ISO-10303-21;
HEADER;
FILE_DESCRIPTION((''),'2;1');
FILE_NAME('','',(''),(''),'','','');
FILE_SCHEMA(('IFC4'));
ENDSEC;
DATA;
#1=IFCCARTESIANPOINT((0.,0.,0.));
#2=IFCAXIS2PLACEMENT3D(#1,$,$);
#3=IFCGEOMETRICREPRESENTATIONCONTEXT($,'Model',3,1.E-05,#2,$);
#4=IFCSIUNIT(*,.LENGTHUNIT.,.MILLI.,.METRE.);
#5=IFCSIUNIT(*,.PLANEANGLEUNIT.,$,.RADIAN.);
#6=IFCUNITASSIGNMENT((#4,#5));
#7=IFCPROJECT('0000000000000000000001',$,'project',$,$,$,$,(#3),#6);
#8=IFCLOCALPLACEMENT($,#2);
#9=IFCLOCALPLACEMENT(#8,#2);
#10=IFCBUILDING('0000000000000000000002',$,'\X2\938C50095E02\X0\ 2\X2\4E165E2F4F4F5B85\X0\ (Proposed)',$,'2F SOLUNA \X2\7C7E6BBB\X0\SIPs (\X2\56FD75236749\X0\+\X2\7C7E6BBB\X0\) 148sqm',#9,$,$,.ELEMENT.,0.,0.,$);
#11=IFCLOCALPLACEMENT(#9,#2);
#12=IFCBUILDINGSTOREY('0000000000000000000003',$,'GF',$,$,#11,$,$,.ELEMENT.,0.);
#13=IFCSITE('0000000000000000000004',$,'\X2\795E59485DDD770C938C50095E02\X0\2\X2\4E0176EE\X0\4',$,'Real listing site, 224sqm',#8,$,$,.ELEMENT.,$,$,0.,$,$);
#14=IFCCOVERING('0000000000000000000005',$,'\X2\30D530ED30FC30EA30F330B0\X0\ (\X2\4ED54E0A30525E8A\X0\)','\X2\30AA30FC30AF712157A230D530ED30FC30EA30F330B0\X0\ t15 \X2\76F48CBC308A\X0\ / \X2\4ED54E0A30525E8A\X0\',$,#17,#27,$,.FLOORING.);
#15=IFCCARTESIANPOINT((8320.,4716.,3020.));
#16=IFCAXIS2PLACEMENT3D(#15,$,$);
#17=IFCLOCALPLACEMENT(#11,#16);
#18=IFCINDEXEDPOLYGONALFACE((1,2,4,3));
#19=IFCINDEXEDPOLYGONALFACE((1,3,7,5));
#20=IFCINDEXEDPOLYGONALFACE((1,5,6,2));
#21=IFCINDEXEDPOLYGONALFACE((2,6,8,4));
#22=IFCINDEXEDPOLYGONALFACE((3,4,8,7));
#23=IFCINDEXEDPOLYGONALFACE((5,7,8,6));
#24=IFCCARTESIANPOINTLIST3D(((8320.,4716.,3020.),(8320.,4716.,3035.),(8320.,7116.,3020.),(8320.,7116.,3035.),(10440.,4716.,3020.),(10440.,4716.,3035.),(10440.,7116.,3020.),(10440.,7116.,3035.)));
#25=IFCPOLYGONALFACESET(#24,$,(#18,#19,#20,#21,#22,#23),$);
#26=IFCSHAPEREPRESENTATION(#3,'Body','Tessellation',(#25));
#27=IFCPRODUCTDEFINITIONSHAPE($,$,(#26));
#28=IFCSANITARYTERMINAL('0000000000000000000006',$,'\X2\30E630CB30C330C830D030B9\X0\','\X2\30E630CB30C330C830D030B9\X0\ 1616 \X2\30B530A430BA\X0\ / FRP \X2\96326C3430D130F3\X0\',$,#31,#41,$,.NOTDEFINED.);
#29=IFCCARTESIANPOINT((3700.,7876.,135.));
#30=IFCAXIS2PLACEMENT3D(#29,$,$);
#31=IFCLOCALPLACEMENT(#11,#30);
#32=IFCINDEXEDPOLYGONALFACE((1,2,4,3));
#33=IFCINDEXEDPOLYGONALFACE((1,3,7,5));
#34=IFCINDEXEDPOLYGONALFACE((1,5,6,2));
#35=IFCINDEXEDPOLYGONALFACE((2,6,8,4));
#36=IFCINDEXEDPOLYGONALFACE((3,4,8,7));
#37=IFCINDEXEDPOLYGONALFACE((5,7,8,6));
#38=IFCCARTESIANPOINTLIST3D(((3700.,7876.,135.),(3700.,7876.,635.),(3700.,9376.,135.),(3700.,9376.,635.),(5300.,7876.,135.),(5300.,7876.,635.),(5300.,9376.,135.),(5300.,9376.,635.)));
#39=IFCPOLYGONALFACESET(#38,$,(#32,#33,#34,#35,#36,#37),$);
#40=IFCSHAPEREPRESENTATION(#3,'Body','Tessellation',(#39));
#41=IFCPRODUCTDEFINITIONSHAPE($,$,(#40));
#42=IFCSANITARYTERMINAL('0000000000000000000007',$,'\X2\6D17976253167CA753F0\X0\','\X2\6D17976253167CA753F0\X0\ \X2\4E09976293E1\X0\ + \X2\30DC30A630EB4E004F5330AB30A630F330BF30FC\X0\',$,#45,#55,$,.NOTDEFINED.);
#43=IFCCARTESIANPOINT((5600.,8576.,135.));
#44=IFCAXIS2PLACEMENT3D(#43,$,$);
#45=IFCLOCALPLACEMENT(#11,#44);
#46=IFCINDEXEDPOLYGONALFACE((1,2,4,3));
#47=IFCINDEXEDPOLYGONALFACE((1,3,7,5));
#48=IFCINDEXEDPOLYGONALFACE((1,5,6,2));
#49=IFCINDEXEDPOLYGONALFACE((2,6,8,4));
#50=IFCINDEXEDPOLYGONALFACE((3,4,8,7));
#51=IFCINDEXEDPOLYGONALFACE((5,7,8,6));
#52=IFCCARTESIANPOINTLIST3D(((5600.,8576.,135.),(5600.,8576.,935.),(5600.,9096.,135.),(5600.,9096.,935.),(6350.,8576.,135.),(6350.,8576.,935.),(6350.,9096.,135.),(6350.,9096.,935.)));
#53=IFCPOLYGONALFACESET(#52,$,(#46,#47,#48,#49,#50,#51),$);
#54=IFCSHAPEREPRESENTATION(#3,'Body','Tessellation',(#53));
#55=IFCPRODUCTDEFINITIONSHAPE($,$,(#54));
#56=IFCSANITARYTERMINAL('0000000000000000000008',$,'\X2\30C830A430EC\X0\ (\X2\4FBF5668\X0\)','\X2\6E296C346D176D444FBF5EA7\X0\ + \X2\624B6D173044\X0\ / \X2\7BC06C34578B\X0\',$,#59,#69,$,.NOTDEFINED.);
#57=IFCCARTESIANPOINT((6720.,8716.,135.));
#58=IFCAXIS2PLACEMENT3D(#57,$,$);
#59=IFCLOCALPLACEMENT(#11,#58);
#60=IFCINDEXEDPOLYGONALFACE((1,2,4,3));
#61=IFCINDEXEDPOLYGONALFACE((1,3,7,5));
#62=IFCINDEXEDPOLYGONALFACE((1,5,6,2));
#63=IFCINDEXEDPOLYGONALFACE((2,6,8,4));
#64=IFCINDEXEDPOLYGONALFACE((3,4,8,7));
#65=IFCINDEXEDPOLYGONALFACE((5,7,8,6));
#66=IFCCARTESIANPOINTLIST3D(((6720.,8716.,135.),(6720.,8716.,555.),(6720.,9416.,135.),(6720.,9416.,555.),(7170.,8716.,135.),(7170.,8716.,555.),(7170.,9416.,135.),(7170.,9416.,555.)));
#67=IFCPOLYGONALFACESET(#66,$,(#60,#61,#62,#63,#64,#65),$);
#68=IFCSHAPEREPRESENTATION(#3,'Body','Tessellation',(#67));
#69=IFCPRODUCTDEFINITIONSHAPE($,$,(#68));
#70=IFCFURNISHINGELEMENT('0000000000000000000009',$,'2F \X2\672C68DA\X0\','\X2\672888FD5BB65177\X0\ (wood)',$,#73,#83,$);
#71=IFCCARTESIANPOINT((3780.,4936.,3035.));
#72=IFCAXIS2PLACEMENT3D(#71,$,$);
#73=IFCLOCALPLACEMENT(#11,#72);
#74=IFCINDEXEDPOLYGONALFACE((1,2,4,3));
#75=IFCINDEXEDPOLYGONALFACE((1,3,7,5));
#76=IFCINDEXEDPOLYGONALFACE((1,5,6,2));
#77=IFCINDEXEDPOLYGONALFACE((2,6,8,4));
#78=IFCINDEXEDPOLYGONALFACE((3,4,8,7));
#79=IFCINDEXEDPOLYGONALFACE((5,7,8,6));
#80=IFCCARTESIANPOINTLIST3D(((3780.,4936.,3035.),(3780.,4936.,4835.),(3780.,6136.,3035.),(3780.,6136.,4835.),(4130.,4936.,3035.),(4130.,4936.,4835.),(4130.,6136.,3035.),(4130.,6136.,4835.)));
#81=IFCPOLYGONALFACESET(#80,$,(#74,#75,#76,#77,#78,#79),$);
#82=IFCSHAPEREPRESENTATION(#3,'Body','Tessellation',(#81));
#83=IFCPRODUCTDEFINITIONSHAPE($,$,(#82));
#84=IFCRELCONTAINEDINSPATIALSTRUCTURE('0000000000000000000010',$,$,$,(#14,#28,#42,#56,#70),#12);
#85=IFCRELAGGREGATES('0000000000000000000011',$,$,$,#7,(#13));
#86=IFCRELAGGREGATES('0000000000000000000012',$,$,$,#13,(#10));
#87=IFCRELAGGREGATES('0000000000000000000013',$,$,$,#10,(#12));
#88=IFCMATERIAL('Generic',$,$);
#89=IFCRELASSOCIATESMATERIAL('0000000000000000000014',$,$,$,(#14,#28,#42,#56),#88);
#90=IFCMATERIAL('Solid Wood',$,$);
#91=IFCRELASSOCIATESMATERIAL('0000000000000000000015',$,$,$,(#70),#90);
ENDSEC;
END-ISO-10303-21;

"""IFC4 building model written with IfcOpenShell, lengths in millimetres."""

from ifc_helpers import new_model, si_unit, frame, frame_2d, origin, place, context, project, spatial, rectangle, extrude, material, element, save


model = new_model("IFC4")

# Units and contexts
model_context = context("Model", 3, precision=1e-05, world=origin())
ifc_project = project(units=[si_unit("LENGTHUNIT", "METRE", prefix="MILLI"), si_unit("PLANEANGLEUNIT", "RADIAN")], contexts=[model_context])

# Site, building, storey
site_placement = place(None, origin())
site = spatial("IfcSite", under=ifc_project, at=site_placement, Name="神奈川県鎌倉市2丁目4", ObjectType="Real listing site, 224sqm", CompositionType="ELEMENT", RefElevation=0.0)
building_placement = place(site_placement, origin())
building = spatial("IfcBuilding", under=site, at=building_placement, Name="鎌倉市 2世帯住宅 (Proposed)", ObjectType="2F SOLUNA 籾殻SIPs (国産杉+籾殻) 148sqm", CompositionType="ELEMENT", ElevationOfRefHeight=0.0, ElevationOfTerrain=0.0)
storey_placement = place(building_placement, origin())
storey = spatial("IfcBuildingStorey", under=building, at=storey_placement, Name="GF", CompositionType="ELEMENT", Elevation=0.0)

# Shared definitions
ifc_material_1 = material(Name="Solid Wood")
ifc_material_2 = material(Name="Generic")

# Covering
covering_1_placement = place(storey_placement, frame((8320.0, 4716.0, 3020.0)))
element("IfcCovering", 1, at=covering_1_placement, inside=storey, material=ifc_material_2, Name="フローリング (仕上げ床)", Description="オーク無垢フローリング t15 直貼り / 仕上げ床", PredefinedType="FLOORING", context=model_context, shape_type="SweptSolid", body=[
    extrude(rectangle(XDim=2120.0, YDim=2400.0, at=frame_2d((1060.0, 1200.0))), frame((8320.0, 4716.0, 3020.0)), (0.0, 0.0, 1.0), 15.0),
])

# Sanitary terminals
sanitary_terminal_1_placement = place(storey_placement, frame((3700.0, 7876.0, 135.0)))
element("IfcSanitaryTerminal", 2, at=sanitary_terminal_1_placement, inside=storey, material=ifc_material_2, Name="ユニットバス", Description="ユニットバス 1616 サイズ / FRP 防水パン", PredefinedType="NOTDEFINED", context=model_context, shape_type="SweptSolid", body=[
    extrude(rectangle(XDim=1600.0, YDim=1500.0, at=frame_2d((800.0, 750.0))), frame((3700.0, 7876.0, 135.0)), (0.0, 0.0, 1.0), 500.0),
])
sanitary_terminal_2_placement = place(storey_placement, frame((5600.0, 8576.0, 135.0)))
element("IfcSanitaryTerminal", 3, at=sanitary_terminal_2_placement, inside=storey, material=ifc_material_2, Name="洗面化粧台", Description="洗面化粧台 三面鏡 + ボウル一体カウンター", PredefinedType="NOTDEFINED", context=model_context, shape_type="SweptSolid", body=[
    extrude(rectangle(XDim=750.0, YDim=520.0, at=frame_2d((375.0, 260.0))), frame((5600.0, 8576.0, 135.0)), (0.0, 0.0, 1.0), 800.0),
])
sanitary_terminal_3_placement = place(storey_placement, frame((6720.0, 8716.0, 135.0)))
element("IfcSanitaryTerminal", 4, at=sanitary_terminal_3_placement, inside=storey, material=ifc_material_2, Name="トイレ (便器)", Description="温水洗浄便座 + 手洗い / 節水型", PredefinedType="NOTDEFINED", context=model_context, shape_type="SweptSolid", body=[
    extrude(rectangle(XDim=450.0, YDim=700.0, at=frame_2d((225.0, 350.0))), frame((6720.0, 8716.0, 135.0)), (0.0, 0.0, 1.0), 420.0),
])

# Furnishing element
furnishing_placement = place(storey_placement, frame((3780.0, 4936.0, 3035.0)))
element("IfcFurnishingElement", 5, at=furnishing_placement, inside=storey, material=ifc_material_1, Name="2F 本棚", Description="木製家具 (wood)", context=model_context, shape_type="SweptSolid", body=[
    extrude(rectangle(XDim=350.0, YDim=1200.0, at=frame_2d((175.0, 600.0))), frame((3780.0, 4936.0, 3035.0)), (0.0, 0.0, 1.0), 1800.0),
])

save(model, "model.ifc")
